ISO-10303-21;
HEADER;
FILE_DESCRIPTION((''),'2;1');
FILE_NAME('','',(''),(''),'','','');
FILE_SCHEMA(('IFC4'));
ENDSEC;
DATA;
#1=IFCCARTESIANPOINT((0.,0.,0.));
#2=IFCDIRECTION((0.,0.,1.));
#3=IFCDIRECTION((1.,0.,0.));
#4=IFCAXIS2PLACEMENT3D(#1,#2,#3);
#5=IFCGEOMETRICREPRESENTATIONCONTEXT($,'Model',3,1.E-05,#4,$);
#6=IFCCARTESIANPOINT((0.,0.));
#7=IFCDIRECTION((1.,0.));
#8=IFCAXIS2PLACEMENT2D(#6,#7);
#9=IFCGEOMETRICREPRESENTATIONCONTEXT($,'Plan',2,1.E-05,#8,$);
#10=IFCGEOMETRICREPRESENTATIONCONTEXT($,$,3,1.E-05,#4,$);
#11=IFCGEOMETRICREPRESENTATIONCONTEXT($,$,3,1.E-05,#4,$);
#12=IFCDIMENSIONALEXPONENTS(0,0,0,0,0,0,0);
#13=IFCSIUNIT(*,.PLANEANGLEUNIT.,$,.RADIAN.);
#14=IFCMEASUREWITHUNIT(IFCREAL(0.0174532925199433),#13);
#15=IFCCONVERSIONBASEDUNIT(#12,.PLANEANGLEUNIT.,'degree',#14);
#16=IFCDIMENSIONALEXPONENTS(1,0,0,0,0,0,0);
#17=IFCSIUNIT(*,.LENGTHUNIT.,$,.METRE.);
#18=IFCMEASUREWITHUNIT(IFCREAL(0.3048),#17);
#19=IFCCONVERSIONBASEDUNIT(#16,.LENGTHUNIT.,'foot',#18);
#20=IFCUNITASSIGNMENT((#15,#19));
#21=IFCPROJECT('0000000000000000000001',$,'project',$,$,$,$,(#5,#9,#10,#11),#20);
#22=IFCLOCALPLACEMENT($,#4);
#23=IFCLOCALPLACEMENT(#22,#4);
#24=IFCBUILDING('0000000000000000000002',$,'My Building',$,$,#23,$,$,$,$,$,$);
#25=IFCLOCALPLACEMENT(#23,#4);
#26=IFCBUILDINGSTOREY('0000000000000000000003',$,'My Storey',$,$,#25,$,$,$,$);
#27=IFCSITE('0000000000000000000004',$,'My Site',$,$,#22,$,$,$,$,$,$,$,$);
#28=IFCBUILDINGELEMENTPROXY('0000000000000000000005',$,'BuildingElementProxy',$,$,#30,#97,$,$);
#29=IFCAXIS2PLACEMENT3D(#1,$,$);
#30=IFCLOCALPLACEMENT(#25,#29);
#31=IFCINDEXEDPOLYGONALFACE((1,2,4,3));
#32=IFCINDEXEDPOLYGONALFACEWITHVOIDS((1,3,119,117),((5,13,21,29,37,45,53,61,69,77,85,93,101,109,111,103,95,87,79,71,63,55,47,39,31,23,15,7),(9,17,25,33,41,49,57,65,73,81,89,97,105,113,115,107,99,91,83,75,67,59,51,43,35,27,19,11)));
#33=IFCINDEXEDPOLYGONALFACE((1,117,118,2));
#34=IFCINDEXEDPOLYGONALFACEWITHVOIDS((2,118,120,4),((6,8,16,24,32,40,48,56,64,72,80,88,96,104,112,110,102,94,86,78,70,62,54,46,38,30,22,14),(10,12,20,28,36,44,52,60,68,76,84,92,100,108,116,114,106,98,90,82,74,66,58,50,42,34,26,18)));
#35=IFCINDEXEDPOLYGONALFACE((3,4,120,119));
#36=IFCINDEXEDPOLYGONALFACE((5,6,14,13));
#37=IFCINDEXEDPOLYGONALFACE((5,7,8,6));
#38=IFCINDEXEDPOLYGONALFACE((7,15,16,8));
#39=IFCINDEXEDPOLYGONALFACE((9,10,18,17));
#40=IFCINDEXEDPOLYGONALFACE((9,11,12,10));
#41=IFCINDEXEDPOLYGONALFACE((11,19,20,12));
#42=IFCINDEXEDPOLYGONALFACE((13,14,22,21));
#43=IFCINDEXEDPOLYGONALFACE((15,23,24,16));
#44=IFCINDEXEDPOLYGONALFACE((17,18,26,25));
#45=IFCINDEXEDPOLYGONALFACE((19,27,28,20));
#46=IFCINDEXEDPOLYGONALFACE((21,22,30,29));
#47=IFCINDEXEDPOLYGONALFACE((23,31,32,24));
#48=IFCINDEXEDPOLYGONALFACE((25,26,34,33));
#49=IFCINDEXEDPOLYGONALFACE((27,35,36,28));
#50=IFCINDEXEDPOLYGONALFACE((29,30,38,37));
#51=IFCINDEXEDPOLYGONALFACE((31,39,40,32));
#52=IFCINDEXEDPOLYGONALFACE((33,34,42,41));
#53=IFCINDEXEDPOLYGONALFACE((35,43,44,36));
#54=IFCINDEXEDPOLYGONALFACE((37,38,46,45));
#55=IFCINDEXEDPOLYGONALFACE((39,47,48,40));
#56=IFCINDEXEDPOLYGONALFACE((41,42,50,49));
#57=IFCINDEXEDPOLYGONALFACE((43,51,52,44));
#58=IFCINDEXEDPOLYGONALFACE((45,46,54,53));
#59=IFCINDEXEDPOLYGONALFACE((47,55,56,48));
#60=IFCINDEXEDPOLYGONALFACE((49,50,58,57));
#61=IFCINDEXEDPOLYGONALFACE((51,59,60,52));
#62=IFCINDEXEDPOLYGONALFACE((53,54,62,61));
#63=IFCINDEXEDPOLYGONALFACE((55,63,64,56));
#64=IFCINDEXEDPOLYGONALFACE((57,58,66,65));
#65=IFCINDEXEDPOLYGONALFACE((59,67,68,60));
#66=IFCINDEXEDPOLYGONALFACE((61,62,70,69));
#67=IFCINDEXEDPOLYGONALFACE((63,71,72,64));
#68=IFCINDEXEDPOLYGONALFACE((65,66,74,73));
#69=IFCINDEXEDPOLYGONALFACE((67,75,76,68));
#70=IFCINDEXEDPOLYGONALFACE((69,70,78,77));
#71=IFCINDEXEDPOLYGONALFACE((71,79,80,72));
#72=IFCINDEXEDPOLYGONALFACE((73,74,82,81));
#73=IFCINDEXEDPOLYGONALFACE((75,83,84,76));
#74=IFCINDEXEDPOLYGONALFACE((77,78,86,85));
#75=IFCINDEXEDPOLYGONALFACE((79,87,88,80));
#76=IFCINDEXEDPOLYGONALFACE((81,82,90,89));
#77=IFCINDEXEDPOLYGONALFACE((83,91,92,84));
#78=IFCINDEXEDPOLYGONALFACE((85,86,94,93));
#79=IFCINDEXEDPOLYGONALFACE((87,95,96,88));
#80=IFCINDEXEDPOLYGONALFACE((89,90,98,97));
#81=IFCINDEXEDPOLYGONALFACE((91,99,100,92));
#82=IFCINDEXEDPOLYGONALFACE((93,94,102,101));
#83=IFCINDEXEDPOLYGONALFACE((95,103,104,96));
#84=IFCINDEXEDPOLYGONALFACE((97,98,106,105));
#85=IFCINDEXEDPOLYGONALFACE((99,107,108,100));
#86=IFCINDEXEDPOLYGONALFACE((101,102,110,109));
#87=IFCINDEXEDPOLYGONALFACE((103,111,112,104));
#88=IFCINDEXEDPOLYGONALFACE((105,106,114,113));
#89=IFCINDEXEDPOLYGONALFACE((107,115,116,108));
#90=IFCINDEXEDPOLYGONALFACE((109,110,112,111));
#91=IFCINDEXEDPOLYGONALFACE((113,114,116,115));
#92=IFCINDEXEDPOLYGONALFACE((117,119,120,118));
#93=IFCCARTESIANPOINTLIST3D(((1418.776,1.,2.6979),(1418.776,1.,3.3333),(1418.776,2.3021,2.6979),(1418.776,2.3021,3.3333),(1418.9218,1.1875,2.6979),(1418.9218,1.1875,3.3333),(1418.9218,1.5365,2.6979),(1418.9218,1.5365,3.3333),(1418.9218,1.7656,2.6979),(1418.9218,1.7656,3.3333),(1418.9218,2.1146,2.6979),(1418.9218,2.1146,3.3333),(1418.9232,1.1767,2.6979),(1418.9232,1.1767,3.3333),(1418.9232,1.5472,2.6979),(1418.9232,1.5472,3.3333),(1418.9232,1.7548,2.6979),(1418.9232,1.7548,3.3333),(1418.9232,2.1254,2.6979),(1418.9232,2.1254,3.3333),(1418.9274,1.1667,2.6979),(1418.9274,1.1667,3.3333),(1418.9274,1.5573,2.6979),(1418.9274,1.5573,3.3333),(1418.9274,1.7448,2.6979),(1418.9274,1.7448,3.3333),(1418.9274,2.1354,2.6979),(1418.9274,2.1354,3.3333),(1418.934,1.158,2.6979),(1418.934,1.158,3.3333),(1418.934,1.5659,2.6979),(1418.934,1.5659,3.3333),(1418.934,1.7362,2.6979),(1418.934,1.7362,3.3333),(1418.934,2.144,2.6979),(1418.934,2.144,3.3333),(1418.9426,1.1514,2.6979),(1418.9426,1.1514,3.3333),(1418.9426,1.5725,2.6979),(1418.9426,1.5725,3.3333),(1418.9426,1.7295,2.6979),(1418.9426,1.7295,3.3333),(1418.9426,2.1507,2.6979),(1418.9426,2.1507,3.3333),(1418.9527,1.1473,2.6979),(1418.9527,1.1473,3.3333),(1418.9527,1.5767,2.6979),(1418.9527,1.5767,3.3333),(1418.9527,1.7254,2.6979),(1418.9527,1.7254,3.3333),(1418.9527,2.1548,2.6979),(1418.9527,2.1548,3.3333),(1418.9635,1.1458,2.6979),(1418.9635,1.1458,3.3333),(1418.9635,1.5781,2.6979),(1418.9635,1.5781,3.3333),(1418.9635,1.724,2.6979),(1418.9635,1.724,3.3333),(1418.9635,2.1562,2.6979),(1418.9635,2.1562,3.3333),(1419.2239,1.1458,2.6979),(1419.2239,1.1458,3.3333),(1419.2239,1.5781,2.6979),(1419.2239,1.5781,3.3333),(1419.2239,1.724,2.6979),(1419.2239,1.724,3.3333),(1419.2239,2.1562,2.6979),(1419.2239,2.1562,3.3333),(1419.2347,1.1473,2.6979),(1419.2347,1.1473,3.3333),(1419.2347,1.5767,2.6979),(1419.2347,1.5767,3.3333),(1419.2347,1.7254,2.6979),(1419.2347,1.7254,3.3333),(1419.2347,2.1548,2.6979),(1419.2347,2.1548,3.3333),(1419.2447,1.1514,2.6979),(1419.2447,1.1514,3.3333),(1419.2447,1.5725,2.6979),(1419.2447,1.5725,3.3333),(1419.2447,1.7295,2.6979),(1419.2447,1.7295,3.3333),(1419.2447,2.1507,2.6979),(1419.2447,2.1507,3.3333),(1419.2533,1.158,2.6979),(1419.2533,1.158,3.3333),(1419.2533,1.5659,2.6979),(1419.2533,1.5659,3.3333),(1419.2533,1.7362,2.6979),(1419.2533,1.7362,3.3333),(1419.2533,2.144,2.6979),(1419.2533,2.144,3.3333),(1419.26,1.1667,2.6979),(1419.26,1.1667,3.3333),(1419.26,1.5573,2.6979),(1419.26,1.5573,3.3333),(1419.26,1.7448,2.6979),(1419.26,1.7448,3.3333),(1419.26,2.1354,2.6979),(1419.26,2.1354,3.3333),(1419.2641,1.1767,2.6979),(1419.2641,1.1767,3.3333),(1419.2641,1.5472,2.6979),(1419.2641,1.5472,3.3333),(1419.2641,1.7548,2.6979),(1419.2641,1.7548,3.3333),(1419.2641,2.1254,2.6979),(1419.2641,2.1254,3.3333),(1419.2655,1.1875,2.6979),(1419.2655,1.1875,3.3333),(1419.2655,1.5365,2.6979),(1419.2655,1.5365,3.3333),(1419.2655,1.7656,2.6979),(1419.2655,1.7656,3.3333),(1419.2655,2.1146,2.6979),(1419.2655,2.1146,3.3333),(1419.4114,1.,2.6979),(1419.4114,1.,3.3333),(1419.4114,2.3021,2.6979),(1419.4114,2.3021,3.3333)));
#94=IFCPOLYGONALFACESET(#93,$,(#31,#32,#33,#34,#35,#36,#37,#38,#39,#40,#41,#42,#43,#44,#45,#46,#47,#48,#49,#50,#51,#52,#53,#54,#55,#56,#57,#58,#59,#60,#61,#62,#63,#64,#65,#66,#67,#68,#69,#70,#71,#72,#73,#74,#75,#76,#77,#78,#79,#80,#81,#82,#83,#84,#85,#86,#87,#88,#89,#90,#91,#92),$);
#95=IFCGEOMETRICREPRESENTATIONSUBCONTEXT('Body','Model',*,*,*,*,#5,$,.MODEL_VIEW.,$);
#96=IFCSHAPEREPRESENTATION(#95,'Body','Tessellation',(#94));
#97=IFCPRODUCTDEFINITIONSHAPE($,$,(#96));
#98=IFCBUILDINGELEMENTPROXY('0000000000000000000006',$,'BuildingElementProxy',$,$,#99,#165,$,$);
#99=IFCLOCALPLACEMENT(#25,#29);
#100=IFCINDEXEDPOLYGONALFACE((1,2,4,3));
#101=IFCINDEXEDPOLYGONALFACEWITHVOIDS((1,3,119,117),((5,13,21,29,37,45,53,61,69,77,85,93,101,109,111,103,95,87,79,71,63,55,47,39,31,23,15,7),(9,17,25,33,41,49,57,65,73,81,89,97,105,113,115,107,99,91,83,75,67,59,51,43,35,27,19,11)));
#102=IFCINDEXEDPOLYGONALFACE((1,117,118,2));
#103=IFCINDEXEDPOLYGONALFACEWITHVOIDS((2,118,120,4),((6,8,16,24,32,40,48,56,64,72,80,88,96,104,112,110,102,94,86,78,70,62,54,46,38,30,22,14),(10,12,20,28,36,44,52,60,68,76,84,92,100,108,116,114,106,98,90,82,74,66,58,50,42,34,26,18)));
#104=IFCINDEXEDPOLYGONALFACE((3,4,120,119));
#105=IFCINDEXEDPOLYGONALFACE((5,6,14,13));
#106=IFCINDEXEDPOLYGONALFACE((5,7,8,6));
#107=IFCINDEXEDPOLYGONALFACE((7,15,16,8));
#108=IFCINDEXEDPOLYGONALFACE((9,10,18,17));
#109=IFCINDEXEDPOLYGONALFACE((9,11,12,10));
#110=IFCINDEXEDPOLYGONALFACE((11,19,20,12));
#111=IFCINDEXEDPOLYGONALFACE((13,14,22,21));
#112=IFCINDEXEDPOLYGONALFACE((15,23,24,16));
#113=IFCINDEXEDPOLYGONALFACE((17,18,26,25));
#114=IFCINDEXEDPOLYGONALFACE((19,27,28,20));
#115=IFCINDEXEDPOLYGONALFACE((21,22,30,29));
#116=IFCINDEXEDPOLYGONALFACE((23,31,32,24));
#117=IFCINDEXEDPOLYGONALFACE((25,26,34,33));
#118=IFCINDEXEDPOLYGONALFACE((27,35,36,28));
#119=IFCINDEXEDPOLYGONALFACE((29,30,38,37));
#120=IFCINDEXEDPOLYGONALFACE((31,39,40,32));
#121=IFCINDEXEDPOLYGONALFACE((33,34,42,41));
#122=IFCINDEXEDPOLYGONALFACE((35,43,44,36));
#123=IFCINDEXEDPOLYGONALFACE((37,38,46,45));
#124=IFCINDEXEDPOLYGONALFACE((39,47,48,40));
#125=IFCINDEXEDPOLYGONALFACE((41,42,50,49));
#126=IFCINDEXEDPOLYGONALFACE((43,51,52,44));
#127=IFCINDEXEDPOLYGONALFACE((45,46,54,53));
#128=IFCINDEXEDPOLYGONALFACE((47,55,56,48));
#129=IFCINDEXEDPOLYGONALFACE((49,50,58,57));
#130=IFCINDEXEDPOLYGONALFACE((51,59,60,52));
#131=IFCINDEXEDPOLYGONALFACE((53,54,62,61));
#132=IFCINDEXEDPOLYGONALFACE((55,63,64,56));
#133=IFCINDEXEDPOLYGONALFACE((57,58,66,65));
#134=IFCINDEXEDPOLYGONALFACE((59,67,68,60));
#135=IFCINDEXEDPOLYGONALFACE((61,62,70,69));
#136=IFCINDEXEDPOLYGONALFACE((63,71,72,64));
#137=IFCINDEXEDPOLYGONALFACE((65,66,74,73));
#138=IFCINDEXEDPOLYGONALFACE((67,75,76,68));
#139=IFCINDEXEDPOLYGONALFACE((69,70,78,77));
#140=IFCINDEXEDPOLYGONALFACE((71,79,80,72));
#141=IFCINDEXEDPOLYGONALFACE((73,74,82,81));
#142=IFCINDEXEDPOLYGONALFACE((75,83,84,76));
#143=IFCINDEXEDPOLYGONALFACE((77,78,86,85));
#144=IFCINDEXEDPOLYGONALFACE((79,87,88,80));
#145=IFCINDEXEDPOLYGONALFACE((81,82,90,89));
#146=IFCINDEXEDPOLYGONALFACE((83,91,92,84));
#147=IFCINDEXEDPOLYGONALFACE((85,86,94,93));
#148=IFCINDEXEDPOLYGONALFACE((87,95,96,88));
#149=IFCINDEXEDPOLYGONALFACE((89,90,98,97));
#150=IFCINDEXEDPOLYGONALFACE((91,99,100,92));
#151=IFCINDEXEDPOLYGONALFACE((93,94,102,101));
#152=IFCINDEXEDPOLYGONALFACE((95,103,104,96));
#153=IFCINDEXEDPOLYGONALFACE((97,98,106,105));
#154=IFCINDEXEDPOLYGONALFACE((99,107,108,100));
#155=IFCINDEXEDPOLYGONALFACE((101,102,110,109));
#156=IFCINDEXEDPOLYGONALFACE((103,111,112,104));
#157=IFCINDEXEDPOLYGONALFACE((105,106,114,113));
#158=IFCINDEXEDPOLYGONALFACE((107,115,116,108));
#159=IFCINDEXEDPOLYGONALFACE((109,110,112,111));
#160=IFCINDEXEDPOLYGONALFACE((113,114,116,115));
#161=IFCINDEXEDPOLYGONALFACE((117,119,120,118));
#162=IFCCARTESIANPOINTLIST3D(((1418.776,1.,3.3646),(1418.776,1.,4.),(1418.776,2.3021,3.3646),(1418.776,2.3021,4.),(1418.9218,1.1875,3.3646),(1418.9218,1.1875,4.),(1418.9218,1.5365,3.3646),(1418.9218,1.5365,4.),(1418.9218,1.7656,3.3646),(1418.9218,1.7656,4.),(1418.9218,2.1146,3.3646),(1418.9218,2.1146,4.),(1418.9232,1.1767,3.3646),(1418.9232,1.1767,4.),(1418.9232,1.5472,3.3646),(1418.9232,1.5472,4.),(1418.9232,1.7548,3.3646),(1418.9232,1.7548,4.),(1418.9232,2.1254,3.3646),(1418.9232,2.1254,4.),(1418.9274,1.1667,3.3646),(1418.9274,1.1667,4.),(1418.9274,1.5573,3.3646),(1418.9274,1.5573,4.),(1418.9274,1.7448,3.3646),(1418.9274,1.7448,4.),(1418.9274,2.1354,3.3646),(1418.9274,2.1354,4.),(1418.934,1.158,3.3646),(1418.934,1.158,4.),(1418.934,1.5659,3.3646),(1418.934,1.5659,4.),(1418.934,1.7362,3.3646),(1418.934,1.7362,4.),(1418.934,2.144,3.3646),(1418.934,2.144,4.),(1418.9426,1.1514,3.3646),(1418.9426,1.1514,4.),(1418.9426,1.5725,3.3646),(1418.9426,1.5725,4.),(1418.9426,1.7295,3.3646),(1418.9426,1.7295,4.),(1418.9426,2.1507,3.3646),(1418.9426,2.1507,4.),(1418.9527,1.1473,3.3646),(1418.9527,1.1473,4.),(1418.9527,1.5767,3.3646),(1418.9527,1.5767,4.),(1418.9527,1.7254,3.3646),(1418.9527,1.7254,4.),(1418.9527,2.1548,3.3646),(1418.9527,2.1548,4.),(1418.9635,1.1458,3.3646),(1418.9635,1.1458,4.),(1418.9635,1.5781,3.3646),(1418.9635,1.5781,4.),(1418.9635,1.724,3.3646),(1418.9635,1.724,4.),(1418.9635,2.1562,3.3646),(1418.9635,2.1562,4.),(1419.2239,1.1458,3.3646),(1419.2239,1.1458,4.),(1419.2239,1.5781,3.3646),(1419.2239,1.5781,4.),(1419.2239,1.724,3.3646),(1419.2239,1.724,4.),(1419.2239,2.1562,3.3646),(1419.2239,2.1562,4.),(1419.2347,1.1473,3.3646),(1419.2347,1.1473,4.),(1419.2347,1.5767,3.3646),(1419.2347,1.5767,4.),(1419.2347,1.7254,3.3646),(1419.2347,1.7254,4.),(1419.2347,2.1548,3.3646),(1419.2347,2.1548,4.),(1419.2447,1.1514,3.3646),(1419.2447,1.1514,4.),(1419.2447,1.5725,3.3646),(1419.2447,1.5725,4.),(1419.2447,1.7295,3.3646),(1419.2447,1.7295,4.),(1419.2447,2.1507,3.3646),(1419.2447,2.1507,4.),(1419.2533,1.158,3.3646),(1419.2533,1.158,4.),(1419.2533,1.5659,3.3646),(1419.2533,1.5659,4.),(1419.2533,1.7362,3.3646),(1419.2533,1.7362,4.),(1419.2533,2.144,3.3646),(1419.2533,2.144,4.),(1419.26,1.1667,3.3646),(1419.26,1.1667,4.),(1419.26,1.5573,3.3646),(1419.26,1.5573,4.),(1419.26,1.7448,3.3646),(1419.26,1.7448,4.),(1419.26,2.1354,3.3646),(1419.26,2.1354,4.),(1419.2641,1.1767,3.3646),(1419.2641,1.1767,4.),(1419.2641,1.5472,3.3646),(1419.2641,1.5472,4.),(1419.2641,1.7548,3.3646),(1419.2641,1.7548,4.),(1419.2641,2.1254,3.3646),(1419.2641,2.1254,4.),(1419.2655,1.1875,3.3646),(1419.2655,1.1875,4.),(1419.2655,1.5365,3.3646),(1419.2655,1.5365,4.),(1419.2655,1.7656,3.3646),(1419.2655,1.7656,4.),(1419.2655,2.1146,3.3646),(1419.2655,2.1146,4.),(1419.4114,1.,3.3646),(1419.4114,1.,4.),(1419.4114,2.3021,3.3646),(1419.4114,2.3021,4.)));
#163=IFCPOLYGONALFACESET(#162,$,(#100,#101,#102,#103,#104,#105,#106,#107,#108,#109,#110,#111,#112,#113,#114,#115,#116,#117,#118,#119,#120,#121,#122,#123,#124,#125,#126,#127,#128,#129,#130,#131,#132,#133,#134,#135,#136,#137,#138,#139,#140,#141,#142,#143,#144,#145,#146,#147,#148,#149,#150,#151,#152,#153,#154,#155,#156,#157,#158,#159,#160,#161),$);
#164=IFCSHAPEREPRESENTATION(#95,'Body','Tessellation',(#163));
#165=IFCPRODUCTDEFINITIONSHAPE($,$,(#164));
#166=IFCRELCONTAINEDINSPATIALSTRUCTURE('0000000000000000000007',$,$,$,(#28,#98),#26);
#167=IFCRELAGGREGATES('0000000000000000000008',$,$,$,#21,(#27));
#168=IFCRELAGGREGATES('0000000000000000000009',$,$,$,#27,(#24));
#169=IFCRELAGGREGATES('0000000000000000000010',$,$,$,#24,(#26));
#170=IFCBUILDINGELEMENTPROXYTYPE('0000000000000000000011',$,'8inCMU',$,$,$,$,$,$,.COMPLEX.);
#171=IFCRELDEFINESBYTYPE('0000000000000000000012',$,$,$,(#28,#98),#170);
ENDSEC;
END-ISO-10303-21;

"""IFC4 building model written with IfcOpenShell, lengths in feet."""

from ifc_helpers import new_model, entity, si_unit, converted_unit, frame, origin_with_axes, origin_2d_with_axis, place, context, subcontext, project, spatial, line, indexed_curve, outline, extrude, source, transform, mapped, type_object, type_shapes, element, save


model = new_model("IFC4")

# Units and contexts
model_context_1 = context("Model", 3, precision=1e-05, world=origin_with_axes())
plan_context = context("Plan", 2, precision=1e-05, world=origin_2d_with_axis())
context_of_model_1 = context(None, 3, precision=1e-05, world=origin_with_axes())
context_of_model_2 = context(None, 3, precision=1e-05, world=origin_with_axes())
body_context_1 = subcontext(model_context_1, "Body", "Model", "MODEL_VIEW")
ifc_project = project(units=[converted_unit("PLANEANGLEUNIT", "degree", entity("IfcReal", 0.0174532925199433), si_unit("PLANEANGLEUNIT", "RADIAN"), dimensions=[0, 0, 0, 0, 0, 0, 0]), converted_unit("LENGTHUNIT", "foot", entity("IfcReal", 0.3048), si_unit("LENGTHUNIT", "METRE"), dimensions=[1, 0, 0, 0, 0, 0, 0])], contexts=[model_context_1, plan_context, context_of_model_1, context_of_model_2])

# Site, building, storey
site_placement = place(None, origin_with_axes())
site = spatial("IfcSite", under=ifc_project, at=site_placement, Name="My Site")
building_placement = place(site_placement, origin_with_axes())
building = spatial("IfcBuilding", under=site, at=building_placement, Name="My Building")
storey_placement = place(building_placement, origin_with_axes())
storey = spatial("IfcBuildingStorey", under=building, at=storey_placement, Name="My Storey")

# Building element proxies
building_element_proxy_type_1 = type_object("IfcBuildingElementProxyType", Name="8inCMU", PredefinedType="COMPLEX")
shared_shape_1 = source(origin_with_axes(), body_context_1, "Body", "SweptSolid", [
    extrude(outline(indexed_curve([(-0.3177, -0.651), (0.3177, -0.651), (0.3177, 0.651), (-0.3177, 0.651), (0.1719, -0.1146), (0.1719, -0.4635), (0.1705, -0.4743), (0.1663, -0.4844), (0.1597, -0.493), (0.151, -0.4996), (0.141, -0.5038), (0.1302, -0.5052), (-0.1302, -0.5052), (-0.141, -0.5038), (-0.151, -0.4996), (-0.1597, -0.493), (-0.1663, -0.4844), (-0.1705, -0.4743), (-0.1719, -0.4635), (-0.1719, -0.1146), (-0.1705, -0.1038), (-0.1663, -0.0938), (-0.1597, -0.0851), (-0.151, -0.0785), (-0.141, -0.0743), (-0.1302, -0.0729), (0.1302, -0.0729), (0.141, -0.0743), (0.151, -0.0785), (0.1597, -0.0851), (0.1663, -0.0938), (0.1705, -0.1038), (0.151, 0.0785), (0.141, 0.0743), (0.1302, 0.0729), (-0.1302, 0.0729), (-0.141, 0.0743), (-0.151, 0.0785), (-0.1597, 0.0851), (-0.1663, 0.0937), (-0.1705, 0.1038), (-0.1719, 0.1146), (-0.1719, 0.4635), (-0.1705, 0.4743), (-0.1663, 0.4844), (-0.1597, 0.493), (-0.151, 0.4996), (-0.141, 0.5038), (-0.1302, 0.5052), (0.1302, 0.5052), (0.141, 0.5038), (0.151, 0.4996), (0.1597, 0.493), (0.1663, 0.4844), (0.1705, 0.4743), (0.1719, 0.4635), (0.1719, 0.1146), (0.1705, 0.1038), (0.1663, 0.0937), (0.1597, 0.0851)], segments=[line(4, 3), line(3, 2), line(2, 1), line(1, 4)], self_intersect=False), holes=[indexed_curve([(-0.3177, -0.651), (0.3177, -0.651), (0.3177, 0.651), (-0.3177, 0.651), (0.1719, -0.1146), (0.1719, -0.4635), (0.1705, -0.4743), (0.1663, -0.4844), (0.1597, -0.493), (0.151, -0.4996), (0.141, -0.5038), (0.1302, -0.5052), (-0.1302, -0.5052), (-0.141, -0.5038), (-0.151, -0.4996), (-0.1597, -0.493), (-0.1663, -0.4844), (-0.1705, -0.4743), (-0.1719, -0.4635), (-0.1719, -0.1146), (-0.1705, -0.1038), (-0.1663, -0.0938), (-0.1597, -0.0851), (-0.151, -0.0785), (-0.141, -0.0743), (-0.1302, -0.0729), (0.1302, -0.0729), (0.141, -0.0743), (0.151, -0.0785), (0.1597, -0.0851), (0.1663, -0.0938), (0.1705, -0.1038), (0.151, 0.0785), (0.141, 0.0743), (0.1302, 0.0729), (-0.1302, 0.0729), (-0.141, 0.0743), (-0.151, 0.0785), (-0.1597, 0.0851), (-0.1663, 0.0937), (-0.1705, 0.1038), (-0.1719, 0.1146), (-0.1719, 0.4635), (-0.1705, 0.4743), (-0.1663, 0.4844), (-0.1597, 0.493), (-0.151, 0.4996), (-0.141, 0.5038), (-0.1302, 0.5052), (0.1302, 0.5052), (0.141, 0.5038), (0.151, 0.4996), (0.1597, 0.493), (0.1663, 0.4844), (0.1705, 0.4743), (0.1719, 0.4635), (0.1719, 0.1146), (0.1705, 0.1038), (0.1663, 0.0937), (0.1597, 0.0851)], segments=[line(20, 19), line(19, 18), line(18, 17), line(17, 16), line(16, 15), line(15, 14), line(14, 13), line(13, 12), line(12, 11), line(11, 10), line(10, 9), line(9, 8), line(8, 7), line(7, 6), line(6, 5), line(5, 32), line(32, 31), line(31, 30), line(30, 29), line(29, 28), line(28, 27), line(27, 26), line(26, 25), line(25, 24), line(24, 23), line(23, 22), line(22, 21), line(21, 20)], self_intersect=False), indexed_curve([(-0.3177, -0.651), (0.3177, -0.651), (0.3177, 0.651), (-0.3177, 0.651), (0.1719, -0.1146), (0.1719, -0.4635), (0.1705, -0.4743), (0.1663, -0.4844), (0.1597, -0.493), (0.151, -0.4996), (0.141, -0.5038), (0.1302, -0.5052), (-0.1302, -0.5052), (-0.141, -0.5038), (-0.151, -0.4996), (-0.1597, -0.493), (-0.1663, -0.4844), (-0.1705, -0.4743), (-0.1719, -0.4635), (-0.1719, -0.1146), (-0.1705, -0.1038), (-0.1663, -0.0938), (-0.1597, -0.0851), (-0.151, -0.0785), (-0.141, -0.0743), (-0.1302, -0.0729), (0.1302, -0.0729), (0.141, -0.0743), (0.151, -0.0785), (0.1597, -0.0851), (0.1663, -0.0938), (0.1705, -0.1038), (0.151, 0.0785), (0.141, 0.0743), (0.1302, 0.0729), (-0.1302, 0.0729), (-0.141, 0.0743), (-0.151, 0.0785), (-0.1597, 0.0851), (-0.1663, 0.0937), (-0.1705, 0.1038), (-0.1719, 0.1146), (-0.1719, 0.4635), (-0.1705, 0.4743), (-0.1663, 0.4844), (-0.1597, 0.493), (-0.151, 0.4996), (-0.141, 0.5038), (-0.1302, 0.5052), (0.1302, 0.5052), (0.141, 0.5038), (0.151, 0.4996), (0.1597, 0.493), (0.1663, 0.4844), (0.1705, 0.4743), (0.1719, 0.4635), (0.1719, 0.1146), (0.1705, 0.1038), (0.1663, 0.0937), (0.1597, 0.0851)], segments=[line(44, 43), line(43, 42), line(42, 41), line(41, 40), line(40, 39), line(39, 38), line(38, 37), line(37, 36), line(36, 35), line(35, 34), line(34, 33), line(33, 60), line(60, 59), line(59, 58), line(58, 57), line(57, 56), line(56, 55), line(55, 54), line(54, 53), line(53, 52), line(52, 51), line(51, 50), line(50, 49), line(49, 48), line(48, 47), line(47, 46), line(46, 45), line(45, 44)], self_intersect=False)]), frame((-0.651, 0.0, 0.0), z_axis=(0.0, 0.0, 1.0), x_axis=(0.0, -1.0, 0.0)), (0.0, 0.0, 1.0), 0.6354),
])
type_shapes(building_element_proxy_type_1, [shared_shape_1])
for number, where, z_axis, x_axis, name in (
    (1, (1419.0936, 2.3021, 2.6979), (0.0, 0.0, 1.0), (0.0, 1.0, 0.0), "BuildingElementProxy"),
    (2, (1419.0936, 2.3021, 3.3646), (0.0, 0.0, 1.0), (0.0, 1.0, 0.0), "BuildingElementProxy"),
):
    element("IfcBuildingElementProxy", number, at=place(storey_placement, frame(where, z_axis=z_axis, x_axis=x_axis)), inside=storey, type_object=building_element_proxy_type_1, Name=name, context=body_context_1, shape_type="MappedRepresentation", body=[
        mapped(shared_shape_1, transform((0.0, 0.0, 0.0), x_axis=(1.0, 0.0, 0.0), y_axis=(0.0, 1.0, 0.0), z_axis=(0.0, 0.0, 1.0), scale=1.0)),
    ])

save(model, "model.ifc")
